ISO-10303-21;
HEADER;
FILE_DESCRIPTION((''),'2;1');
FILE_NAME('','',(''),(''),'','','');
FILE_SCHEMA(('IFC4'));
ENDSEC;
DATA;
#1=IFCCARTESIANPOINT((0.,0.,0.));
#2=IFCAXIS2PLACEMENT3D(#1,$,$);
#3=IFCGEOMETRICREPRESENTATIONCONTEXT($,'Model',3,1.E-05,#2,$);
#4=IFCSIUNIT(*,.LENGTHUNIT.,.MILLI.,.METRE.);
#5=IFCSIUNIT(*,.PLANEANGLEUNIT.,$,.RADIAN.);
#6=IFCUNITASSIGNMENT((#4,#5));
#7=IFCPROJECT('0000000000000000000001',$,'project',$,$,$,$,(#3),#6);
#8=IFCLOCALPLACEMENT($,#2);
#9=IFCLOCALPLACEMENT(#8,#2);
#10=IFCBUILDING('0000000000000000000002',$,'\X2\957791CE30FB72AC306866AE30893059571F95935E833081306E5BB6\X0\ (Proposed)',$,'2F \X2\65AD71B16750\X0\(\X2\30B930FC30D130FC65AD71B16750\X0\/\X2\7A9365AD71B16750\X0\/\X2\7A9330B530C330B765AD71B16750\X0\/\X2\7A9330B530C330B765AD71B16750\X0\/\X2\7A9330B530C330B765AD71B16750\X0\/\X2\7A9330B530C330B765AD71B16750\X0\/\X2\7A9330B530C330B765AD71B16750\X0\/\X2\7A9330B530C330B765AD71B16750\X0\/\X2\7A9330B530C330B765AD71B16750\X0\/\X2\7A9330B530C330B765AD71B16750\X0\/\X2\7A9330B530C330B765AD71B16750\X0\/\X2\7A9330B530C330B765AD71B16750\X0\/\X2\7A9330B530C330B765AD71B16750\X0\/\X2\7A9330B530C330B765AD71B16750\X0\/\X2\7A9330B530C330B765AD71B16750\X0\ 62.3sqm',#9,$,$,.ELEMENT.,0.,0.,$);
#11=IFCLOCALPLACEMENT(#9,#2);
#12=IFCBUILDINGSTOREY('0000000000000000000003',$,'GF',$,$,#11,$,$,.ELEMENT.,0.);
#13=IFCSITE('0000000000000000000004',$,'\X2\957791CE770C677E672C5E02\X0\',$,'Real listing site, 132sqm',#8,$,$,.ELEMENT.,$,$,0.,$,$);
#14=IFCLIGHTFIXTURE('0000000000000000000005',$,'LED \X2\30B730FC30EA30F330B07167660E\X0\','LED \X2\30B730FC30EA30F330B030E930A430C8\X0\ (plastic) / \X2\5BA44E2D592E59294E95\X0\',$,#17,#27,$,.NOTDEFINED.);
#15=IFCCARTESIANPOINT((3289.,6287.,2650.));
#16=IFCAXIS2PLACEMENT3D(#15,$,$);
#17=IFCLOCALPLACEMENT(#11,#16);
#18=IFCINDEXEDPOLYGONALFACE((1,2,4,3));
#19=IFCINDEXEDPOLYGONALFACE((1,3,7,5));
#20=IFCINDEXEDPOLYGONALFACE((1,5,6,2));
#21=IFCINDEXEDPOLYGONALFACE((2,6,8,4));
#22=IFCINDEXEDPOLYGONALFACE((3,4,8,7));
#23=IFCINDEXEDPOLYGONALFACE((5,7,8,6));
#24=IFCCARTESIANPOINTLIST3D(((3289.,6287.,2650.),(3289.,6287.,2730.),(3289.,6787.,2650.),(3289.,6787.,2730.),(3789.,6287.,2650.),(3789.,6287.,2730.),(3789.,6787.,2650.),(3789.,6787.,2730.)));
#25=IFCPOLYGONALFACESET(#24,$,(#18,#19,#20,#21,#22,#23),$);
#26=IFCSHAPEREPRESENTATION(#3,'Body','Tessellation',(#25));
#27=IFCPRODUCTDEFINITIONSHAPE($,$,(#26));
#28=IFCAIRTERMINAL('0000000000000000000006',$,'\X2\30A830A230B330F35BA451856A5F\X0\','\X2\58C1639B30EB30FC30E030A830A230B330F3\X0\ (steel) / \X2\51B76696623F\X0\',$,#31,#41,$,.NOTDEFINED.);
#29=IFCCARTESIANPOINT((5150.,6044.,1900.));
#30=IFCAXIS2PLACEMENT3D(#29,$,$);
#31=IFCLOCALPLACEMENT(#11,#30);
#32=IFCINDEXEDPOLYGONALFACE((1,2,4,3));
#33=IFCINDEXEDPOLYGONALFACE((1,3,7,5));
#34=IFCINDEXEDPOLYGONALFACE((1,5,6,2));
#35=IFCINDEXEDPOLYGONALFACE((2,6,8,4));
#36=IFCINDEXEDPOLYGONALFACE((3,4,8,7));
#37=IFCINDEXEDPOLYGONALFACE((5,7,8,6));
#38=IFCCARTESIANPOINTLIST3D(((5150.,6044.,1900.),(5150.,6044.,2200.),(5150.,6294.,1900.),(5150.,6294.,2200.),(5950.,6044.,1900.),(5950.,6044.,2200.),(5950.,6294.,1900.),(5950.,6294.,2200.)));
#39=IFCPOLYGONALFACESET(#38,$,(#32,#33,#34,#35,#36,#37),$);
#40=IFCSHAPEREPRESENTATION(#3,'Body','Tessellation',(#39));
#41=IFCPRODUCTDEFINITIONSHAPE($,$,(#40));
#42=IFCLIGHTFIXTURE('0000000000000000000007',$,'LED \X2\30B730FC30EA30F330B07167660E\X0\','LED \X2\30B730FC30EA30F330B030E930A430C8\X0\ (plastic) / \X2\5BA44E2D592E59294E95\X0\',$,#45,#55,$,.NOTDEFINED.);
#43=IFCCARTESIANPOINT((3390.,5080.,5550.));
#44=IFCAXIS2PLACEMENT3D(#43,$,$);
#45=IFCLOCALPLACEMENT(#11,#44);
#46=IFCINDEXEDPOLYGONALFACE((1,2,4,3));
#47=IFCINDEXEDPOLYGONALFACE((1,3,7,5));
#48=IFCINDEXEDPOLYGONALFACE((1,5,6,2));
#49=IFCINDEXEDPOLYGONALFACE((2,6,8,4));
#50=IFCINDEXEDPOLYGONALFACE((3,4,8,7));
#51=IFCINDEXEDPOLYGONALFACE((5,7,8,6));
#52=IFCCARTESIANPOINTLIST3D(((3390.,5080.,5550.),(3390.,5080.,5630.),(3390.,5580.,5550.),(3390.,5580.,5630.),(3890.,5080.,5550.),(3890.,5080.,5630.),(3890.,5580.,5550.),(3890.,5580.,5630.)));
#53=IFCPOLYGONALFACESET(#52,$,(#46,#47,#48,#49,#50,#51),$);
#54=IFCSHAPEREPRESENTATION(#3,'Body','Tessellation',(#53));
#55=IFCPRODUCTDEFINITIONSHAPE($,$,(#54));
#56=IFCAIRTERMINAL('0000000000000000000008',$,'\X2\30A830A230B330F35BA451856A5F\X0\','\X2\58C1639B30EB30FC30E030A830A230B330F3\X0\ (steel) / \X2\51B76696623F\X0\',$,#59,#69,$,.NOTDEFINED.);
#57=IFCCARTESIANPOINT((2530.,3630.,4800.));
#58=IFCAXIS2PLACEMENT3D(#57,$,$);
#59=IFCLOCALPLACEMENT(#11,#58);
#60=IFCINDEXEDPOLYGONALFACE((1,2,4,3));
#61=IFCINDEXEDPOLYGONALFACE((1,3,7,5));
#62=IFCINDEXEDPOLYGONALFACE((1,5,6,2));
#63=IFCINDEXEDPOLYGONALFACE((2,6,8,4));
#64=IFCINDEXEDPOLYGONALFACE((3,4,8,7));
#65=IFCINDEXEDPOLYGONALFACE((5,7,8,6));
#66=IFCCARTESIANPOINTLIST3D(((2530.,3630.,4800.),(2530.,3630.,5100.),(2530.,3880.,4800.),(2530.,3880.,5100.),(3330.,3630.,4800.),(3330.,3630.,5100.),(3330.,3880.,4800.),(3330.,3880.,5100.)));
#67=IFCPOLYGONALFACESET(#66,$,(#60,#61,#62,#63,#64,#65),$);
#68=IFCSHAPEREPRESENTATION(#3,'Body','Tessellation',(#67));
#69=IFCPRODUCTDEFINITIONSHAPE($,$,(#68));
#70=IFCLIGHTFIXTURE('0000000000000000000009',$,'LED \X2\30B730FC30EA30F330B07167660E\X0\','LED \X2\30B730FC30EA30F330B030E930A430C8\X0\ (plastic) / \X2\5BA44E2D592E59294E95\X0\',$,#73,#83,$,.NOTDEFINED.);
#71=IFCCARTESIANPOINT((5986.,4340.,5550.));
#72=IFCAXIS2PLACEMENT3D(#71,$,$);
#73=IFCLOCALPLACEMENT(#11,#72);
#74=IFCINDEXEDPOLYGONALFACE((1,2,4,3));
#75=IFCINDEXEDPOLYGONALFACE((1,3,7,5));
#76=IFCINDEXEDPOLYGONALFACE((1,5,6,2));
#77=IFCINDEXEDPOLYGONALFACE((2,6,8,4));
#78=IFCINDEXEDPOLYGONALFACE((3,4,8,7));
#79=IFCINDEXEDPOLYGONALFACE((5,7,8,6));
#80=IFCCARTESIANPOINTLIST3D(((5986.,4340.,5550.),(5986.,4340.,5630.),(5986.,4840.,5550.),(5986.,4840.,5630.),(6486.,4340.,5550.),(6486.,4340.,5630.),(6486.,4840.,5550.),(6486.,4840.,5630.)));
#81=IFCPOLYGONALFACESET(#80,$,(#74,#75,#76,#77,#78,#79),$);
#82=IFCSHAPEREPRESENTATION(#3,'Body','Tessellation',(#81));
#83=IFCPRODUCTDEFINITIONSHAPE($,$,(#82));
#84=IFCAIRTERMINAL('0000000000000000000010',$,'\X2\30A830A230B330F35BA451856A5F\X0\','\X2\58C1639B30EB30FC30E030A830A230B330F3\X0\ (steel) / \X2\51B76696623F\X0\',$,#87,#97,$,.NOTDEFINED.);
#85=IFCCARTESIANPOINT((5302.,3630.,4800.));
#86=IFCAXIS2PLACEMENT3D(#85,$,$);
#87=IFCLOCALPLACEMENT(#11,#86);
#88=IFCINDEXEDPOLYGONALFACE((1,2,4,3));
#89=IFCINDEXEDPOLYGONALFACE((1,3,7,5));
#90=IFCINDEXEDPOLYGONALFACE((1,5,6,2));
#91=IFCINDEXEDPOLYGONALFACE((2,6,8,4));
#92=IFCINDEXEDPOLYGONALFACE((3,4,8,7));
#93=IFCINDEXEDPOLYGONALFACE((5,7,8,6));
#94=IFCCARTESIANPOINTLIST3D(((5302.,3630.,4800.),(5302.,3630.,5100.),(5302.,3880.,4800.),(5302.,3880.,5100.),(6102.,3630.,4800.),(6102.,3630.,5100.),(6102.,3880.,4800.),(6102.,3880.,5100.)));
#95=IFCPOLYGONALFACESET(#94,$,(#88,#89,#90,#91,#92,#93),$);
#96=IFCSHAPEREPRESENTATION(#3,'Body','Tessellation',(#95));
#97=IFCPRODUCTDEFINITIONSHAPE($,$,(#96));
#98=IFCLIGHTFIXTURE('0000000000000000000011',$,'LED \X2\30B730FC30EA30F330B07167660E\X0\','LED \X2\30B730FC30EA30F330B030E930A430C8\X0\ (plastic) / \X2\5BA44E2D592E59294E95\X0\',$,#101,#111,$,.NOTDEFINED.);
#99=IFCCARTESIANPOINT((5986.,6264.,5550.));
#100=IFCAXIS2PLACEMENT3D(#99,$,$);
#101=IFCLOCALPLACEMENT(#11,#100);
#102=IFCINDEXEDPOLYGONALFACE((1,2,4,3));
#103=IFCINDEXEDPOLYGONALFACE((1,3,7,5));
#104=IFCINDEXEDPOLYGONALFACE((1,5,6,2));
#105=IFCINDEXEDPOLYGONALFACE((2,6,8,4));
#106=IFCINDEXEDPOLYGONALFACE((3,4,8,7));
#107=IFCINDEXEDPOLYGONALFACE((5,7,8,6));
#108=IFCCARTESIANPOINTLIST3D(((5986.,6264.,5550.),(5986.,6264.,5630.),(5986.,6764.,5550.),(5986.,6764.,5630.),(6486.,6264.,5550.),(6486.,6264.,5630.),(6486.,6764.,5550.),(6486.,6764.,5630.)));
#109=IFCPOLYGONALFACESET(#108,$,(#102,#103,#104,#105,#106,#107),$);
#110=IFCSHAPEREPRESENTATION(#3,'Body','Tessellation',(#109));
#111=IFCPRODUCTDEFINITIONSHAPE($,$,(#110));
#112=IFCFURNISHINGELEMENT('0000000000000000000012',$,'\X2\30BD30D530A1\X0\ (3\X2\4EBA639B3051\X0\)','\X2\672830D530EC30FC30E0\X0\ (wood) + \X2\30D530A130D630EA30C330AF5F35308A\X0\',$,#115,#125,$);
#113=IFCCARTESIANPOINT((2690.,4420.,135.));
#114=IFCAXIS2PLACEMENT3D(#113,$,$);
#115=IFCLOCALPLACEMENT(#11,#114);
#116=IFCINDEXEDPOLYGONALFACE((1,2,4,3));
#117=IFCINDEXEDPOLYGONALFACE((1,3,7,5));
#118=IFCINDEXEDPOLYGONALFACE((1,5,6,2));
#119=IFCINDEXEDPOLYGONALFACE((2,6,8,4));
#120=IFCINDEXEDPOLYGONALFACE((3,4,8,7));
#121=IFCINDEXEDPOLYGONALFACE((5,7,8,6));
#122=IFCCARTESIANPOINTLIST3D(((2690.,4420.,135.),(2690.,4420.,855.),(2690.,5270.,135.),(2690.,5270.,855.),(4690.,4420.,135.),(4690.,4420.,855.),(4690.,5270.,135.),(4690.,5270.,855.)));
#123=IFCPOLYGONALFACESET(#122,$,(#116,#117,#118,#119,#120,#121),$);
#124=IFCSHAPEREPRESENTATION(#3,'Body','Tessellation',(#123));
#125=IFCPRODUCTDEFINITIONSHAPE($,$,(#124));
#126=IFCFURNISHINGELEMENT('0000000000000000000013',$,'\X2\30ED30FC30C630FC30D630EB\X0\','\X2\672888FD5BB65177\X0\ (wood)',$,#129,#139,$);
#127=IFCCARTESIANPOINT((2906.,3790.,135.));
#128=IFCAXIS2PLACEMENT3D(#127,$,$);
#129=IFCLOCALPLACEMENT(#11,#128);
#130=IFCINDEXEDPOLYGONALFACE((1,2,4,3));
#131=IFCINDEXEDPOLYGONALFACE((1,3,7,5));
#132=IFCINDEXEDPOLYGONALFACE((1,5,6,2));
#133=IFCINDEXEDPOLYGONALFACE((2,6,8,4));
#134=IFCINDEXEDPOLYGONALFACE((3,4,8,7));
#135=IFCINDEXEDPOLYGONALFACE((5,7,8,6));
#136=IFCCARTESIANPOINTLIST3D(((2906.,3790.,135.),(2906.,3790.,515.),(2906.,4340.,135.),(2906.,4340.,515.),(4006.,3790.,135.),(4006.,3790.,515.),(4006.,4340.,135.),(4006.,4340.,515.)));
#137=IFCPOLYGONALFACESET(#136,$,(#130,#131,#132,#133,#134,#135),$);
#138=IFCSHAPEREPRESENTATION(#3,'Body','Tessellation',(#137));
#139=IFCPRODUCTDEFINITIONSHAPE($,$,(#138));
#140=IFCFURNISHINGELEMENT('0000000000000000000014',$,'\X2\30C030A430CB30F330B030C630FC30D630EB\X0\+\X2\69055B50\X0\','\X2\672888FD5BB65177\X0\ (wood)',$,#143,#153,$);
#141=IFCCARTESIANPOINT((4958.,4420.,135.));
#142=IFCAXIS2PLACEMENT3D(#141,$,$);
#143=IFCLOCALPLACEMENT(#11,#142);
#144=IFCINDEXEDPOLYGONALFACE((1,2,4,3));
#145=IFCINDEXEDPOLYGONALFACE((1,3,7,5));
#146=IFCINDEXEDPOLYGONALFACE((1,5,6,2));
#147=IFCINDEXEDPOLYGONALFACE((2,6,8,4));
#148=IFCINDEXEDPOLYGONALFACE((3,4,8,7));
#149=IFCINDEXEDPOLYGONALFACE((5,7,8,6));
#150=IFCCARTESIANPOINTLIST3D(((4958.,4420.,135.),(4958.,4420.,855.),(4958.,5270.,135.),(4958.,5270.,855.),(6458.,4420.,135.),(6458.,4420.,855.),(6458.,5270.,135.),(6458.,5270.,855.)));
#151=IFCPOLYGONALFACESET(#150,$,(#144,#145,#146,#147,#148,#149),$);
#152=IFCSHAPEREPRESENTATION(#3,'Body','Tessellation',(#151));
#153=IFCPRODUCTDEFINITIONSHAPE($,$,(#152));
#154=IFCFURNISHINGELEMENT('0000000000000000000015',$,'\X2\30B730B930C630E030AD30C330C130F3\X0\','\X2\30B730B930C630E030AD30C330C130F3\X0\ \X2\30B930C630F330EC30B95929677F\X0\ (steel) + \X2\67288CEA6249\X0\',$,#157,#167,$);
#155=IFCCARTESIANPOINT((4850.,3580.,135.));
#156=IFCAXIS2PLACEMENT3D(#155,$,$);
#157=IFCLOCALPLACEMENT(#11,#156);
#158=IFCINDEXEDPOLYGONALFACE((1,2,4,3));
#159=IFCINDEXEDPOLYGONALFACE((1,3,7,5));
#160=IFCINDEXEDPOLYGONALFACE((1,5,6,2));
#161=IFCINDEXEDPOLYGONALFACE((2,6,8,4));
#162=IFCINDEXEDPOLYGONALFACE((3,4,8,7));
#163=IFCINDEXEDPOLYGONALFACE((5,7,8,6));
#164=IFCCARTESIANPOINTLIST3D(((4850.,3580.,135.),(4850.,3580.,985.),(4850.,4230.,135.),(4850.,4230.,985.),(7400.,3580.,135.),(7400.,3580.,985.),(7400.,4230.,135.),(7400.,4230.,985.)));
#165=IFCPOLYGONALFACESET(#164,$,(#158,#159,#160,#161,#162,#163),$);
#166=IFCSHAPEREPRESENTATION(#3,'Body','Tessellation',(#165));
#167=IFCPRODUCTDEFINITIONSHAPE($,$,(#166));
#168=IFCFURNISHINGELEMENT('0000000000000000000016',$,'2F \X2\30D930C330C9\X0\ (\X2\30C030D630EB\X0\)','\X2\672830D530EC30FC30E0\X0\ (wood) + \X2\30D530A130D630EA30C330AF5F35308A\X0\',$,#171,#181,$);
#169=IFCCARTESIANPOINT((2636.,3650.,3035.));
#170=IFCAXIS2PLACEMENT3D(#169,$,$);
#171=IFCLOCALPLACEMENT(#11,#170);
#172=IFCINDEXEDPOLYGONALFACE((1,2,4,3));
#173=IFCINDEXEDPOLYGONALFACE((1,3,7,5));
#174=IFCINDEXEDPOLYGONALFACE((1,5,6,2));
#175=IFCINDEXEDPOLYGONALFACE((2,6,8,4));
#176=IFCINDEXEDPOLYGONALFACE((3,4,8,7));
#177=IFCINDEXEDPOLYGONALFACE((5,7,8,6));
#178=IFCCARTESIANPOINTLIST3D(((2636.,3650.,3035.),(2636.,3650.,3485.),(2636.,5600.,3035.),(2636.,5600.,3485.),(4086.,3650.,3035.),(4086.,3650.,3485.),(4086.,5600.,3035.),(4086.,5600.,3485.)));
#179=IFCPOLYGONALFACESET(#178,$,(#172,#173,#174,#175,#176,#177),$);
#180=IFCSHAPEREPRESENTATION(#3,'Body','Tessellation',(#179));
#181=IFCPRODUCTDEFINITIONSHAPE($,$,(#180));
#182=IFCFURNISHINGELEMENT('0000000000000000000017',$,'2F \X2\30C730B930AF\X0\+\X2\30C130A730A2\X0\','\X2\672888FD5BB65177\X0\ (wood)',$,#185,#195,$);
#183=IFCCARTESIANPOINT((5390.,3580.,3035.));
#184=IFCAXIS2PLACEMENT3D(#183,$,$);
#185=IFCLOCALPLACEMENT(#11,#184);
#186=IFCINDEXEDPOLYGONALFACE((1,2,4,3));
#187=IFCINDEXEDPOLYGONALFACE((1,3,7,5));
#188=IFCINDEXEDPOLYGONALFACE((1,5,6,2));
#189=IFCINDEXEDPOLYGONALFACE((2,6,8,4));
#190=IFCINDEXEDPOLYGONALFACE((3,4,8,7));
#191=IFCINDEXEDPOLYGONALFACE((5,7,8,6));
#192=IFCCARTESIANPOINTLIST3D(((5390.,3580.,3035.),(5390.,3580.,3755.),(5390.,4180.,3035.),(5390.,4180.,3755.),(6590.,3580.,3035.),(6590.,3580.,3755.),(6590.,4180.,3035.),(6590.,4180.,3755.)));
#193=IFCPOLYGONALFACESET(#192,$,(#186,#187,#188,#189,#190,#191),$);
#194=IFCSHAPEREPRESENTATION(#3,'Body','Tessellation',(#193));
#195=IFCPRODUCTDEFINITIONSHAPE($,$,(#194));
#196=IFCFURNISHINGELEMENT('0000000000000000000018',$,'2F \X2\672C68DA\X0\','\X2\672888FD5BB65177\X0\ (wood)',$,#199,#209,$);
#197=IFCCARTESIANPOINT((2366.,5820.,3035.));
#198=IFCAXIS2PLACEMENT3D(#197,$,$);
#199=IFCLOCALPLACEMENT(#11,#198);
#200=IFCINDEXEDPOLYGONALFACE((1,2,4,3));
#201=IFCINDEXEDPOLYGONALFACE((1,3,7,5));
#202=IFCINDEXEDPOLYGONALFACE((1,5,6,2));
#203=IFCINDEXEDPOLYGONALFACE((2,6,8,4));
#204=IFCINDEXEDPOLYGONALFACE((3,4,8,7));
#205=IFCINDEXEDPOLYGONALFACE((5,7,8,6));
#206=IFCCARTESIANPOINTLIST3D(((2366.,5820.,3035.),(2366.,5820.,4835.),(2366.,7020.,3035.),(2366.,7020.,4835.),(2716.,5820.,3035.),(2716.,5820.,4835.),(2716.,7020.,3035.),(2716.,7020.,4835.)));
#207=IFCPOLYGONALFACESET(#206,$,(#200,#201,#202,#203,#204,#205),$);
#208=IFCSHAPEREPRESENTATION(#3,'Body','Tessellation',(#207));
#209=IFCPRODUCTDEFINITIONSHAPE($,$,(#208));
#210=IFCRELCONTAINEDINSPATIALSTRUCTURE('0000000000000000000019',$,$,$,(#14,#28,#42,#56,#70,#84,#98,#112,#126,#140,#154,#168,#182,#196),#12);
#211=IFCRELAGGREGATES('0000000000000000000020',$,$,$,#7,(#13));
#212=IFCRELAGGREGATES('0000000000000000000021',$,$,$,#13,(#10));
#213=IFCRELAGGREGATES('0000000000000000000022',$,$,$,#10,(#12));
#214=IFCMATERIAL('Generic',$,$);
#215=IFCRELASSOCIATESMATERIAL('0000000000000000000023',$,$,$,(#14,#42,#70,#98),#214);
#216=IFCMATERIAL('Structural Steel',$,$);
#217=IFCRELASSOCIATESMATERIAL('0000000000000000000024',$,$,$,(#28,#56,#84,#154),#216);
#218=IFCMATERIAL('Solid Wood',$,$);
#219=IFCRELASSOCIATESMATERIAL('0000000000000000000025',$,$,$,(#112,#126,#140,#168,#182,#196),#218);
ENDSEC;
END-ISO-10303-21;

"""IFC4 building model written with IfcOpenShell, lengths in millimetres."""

from ifc_helpers import new_model, si_unit, frame, frame_2d, origin, place, context, project, spatial, rectangle, extrude, material, element, save


model = new_model("IFC4")

# Units and contexts
model_context = context("Model", 3, precision=1e-05, world=origin())
ifc_project = project(units=[si_unit("LENGTHUNIT", "METRE", prefix="MILLI"), si_unit("PLANEANGLEUNIT", "RADIAN")], contexts=[model_context])

# Site, building, storey
site_placement = place(None, origin())
site = spatial("IfcSite", under=ifc_project, at=site_placement, Name="長野県松本市", ObjectType="Real listing site, 132sqm", CompositionType="ELEMENT", RefElevation=0.0)
building_placement = place(site_placement, origin())
building = spatial("IfcBuilding", under=site, at=building_placement, Name="長野・犬と暮らす土間広めの家 (Proposed)", ObjectType="2F 断熱材(スーパー断熱材/窓断熱材/窓サッシ断熱材/窓サッシ断熱材/窓サッシ断熱材/窓サッシ断熱材/窓サッシ断熱材/窓サッシ断熱材/窓サッシ断熱材/窓サッシ断熱材/窓サッシ断熱材/窓サッシ断熱材/窓サッシ断熱材/窓サッシ断熱材/窓サッシ断熱材 62.3sqm", CompositionType="ELEMENT", ElevationOfRefHeight=0.0, ElevationOfTerrain=0.0)
storey_placement = place(building_placement, origin())
storey = spatial("IfcBuildingStorey", under=building, at=storey_placement, Name="GF", CompositionType="ELEMENT", Elevation=0.0)

# Shared definitions
ifc_material_1 = material(Name="Solid Wood")

# Shared definitions
ifc_material_2 = material(Name="Structural Steel")

# Shared definitions
ifc_material_3 = material(Name="Generic")

# Light fixture
light_fixture_1_placement = place(storey_placement, frame((3289.0, 6287.0, 2650.0)))
element("IfcLightFixture", 1, at=light_fixture_1_placement, inside=storey, material=ifc_material_3, Name="LED シーリング照明", Description="LED シーリングライト (plastic) / 室中央天井", PredefinedType="NOTDEFINED", context=model_context, shape_type="SweptSolid", body=[
    extrude(rectangle(XDim=500.0, YDim=500.0, at=frame_2d((250.0, 250.0))), frame((3289.0, 6287.0, 2650.0)), (0.0, 0.0, 1.0), 80.0),
])

# Air terminal
air_terminal_1_placement = place(storey_placement, frame((5150.0, 6044.0, 1900.0)))
element("IfcAirTerminal", 2, at=air_terminal_1_placement, inside=storey, material=ifc_material_2, Name="エアコン室内機", Description="壁掛ルームエアコン (steel) / 冷暖房", PredefinedType="NOTDEFINED", context=model_context, shape_type="SweptSolid", body=[
    extrude(rectangle(XDim=800.0, YDim=250.0, at=frame_2d((400.0, 125.0))), frame((5150.0, 6044.0, 1900.0)), (0.0, 0.0, 1.0), 300.0),
])

# Light fixture
light_fixture_2_placement = place(storey_placement, frame((3390.0, 5080.0, 5550.0)))
element("IfcLightFixture", 3, at=light_fixture_2_placement, inside=storey, material=ifc_material_3, Name="LED シーリング照明", Description="LED シーリングライト (plastic) / 室中央天井", PredefinedType="NOTDEFINED", context=model_context, shape_type="SweptSolid", body=[
    extrude(rectangle(XDim=500.0, YDim=500.0, at=frame_2d((250.0, 250.0))), frame((3390.0, 5080.0, 5550.0)), (0.0, 0.0, 1.0), 80.0),
])

# Air terminal
air_terminal_2_placement = place(storey_placement, frame((2530.0, 3630.0, 4800.0)))
element("IfcAirTerminal", 4, at=air_terminal_2_placement, inside=storey, material=ifc_material_2, Name="エアコン室内機", Description="壁掛ルームエアコン (steel) / 冷暖房", PredefinedType="NOTDEFINED", context=model_context, shape_type="SweptSolid", body=[
    extrude(rectangle(XDim=800.0, YDim=250.0, at=frame_2d((400.0, 125.0))), frame((2530.0, 3630.0, 4800.0)), (0.0, 0.0, 1.0), 300.0),
])

# Light fixture
light_fixture_3_placement = place(storey_placement, frame((5986.0, 4340.0, 5550.0)))
element("IfcLightFixture", 5, at=light_fixture_3_placement, inside=storey, material=ifc_material_3, Name="LED シーリング照明", Description="LED シーリングライト (plastic) / 室中央天井", PredefinedType="NOTDEFINED", context=model_context, shape_type="SweptSolid", body=[
    extrude(rectangle(XDim=500.0, YDim=500.0, at=frame_2d((250.0, 250.0))), frame((5986.0, 4340.0, 5550.0)), (0.0, 0.0, 1.0), 80.0),
])

# Air terminal
air_terminal_3_placement = place(storey_placement, frame((5302.0, 3630.0, 4800.0)))
element("IfcAirTerminal", 6, at=air_terminal_3_placement, inside=storey, material=ifc_material_2, Name="エアコン室内機", Description="壁掛ルームエアコン (steel) / 冷暖房", PredefinedType="NOTDEFINED", context=model_context, shape_type="SweptSolid", body=[
    extrude(rectangle(XDim=800.0, YDim=250.0, at=frame_2d((400.0, 125.0))), frame((5302.0, 3630.0, 4800.0)), (0.0, 0.0, 1.0), 300.0),
])

# Light fixture
light_fixture_4_placement = place(storey_placement, frame((5986.0, 6264.0, 5550.0)))
element("IfcLightFixture", 7, at=light_fixture_4_placement, inside=storey, material=ifc_material_3, Name="LED シーリング照明", Description="LED シーリングライト (plastic) / 室中央天井", PredefinedType="NOTDEFINED", context=model_context, shape_type="SweptSolid", body=[
    extrude(rectangle(XDim=500.0, YDim=500.0, at=frame_2d((250.0, 250.0))), frame((5986.0, 6264.0, 5550.0)), (0.0, 0.0, 1.0), 80.0),
])

# Furnishing elements
furnishing_1_placement = place(storey_placement, frame((2690.0, 4420.0, 135.0)))
element("IfcFurnishingElement", 8, at=furnishing_1_placement, inside=storey, material=ifc_material_1, Name="ソファ (3人掛け)", Description="木フレーム (wood) + ファブリック張り", context=model_context, shape_type="SweptSolid", body=[
    extrude(rectangle(XDim=2000.0, YDim=850.0, at=frame_2d((1000.0, 425.0))), frame((2690.0, 4420.0, 135.0)), (0.0, 0.0, 1.0), 720.0),
])
furnishing_2_placement = place(storey_placement, frame((2906.0, 3790.0, 135.0)))
element("IfcFurnishingElement", 9, at=furnishing_2_placement, inside=storey, material=ifc_material_1, Name="ローテーブル", Description="木製家具 (wood)", context=model_context, shape_type="SweptSolid", body=[
    extrude(rectangle(XDim=1100.0, YDim=550.0, at=frame_2d((550.0, 275.0))), frame((2906.0, 3790.0, 135.0)), (0.0, 0.0, 1.0), 380.0),
])
furnishing_3_placement = place(storey_placement, frame((4958.0, 4420.0, 135.0)))
element("IfcFurnishingElement", 10, at=furnishing_3_placement, inside=storey, material=ifc_material_1, Name="ダイニングテーブル+椅子", Description="木製家具 (wood)", context=model_context, shape_type="SweptSolid", body=[
    extrude(rectangle(XDim=1500.0, YDim=850.0, at=frame_2d((750.0, 425.0))), frame((4958.0, 4420.0, 135.0)), (0.0, 0.0, 1.0), 720.0),
])
furnishing_4_placement = place(storey_placement, frame((4850.0, 3580.0, 135.0)))
element("IfcFurnishingElement", 11, at=furnishing_4_placement, inside=storey, material=ifc_material_2, Name="システムキッチン", Description="システムキッチン ステンレス天板 (steel) + 木質扉", context=model_context, shape_type="SweptSolid", body=[
    extrude(rectangle(XDim=2550.0, YDim=650.0, at=frame_2d((1275.0, 325.0))), frame((4850.0, 3580.0, 135.0)), (0.0, 0.0, 1.0), 850.0),
])
furnishing_5_placement = place(storey_placement, frame((2636.0, 3650.0, 3035.0)))
element("IfcFurnishingElement", 12, at=furnishing_5_placement, inside=storey, material=ifc_material_1, Name="2F ベッド (ダブル)", Description="木フレーム (wood) + ファブリック張り", context=model_context, shape_type="SweptSolid", body=[
    extrude(rectangle(XDim=1450.0, YDim=1950.0, at=frame_2d((725.0, 975.0))), frame((2636.0, 3650.0, 3035.0)), (0.0, 0.0, 1.0), 450.0),
])
furnishing_6_placement = place(storey_placement, frame((5390.0, 3580.0, 3035.0)))
element("IfcFurnishingElement", 13, at=furnishing_6_placement, inside=storey, material=ifc_material_1, Name="2F デスク+チェア", Description="木製家具 (wood)", context=model_context, shape_type="SweptSolid", body=[
    extrude(rectangle(XDim=1200.0, YDim=600.0, at=frame_2d((600.0, 300.0))), frame((5390.0, 3580.0, 3035.0)), (0.0, 0.0, 1.0), 720.0),
])
furnishing_7_placement = place(storey_placement, frame((2366.0, 5820.0, 3035.0)))
element("IfcFurnishingElement", 14, at=furnishing_7_placement, inside=storey, material=ifc_material_1, Name="2F 本棚", Description="木製家具 (wood)", context=model_context, shape_type="SweptSolid", body=[
    extrude(rectangle(XDim=350.0, YDim=1200.0, at=frame_2d((175.0, 600.0))), frame((2366.0, 5820.0, 3035.0)), (0.0, 0.0, 1.0), 1800.0),
])

save(model, "model.ifc")
